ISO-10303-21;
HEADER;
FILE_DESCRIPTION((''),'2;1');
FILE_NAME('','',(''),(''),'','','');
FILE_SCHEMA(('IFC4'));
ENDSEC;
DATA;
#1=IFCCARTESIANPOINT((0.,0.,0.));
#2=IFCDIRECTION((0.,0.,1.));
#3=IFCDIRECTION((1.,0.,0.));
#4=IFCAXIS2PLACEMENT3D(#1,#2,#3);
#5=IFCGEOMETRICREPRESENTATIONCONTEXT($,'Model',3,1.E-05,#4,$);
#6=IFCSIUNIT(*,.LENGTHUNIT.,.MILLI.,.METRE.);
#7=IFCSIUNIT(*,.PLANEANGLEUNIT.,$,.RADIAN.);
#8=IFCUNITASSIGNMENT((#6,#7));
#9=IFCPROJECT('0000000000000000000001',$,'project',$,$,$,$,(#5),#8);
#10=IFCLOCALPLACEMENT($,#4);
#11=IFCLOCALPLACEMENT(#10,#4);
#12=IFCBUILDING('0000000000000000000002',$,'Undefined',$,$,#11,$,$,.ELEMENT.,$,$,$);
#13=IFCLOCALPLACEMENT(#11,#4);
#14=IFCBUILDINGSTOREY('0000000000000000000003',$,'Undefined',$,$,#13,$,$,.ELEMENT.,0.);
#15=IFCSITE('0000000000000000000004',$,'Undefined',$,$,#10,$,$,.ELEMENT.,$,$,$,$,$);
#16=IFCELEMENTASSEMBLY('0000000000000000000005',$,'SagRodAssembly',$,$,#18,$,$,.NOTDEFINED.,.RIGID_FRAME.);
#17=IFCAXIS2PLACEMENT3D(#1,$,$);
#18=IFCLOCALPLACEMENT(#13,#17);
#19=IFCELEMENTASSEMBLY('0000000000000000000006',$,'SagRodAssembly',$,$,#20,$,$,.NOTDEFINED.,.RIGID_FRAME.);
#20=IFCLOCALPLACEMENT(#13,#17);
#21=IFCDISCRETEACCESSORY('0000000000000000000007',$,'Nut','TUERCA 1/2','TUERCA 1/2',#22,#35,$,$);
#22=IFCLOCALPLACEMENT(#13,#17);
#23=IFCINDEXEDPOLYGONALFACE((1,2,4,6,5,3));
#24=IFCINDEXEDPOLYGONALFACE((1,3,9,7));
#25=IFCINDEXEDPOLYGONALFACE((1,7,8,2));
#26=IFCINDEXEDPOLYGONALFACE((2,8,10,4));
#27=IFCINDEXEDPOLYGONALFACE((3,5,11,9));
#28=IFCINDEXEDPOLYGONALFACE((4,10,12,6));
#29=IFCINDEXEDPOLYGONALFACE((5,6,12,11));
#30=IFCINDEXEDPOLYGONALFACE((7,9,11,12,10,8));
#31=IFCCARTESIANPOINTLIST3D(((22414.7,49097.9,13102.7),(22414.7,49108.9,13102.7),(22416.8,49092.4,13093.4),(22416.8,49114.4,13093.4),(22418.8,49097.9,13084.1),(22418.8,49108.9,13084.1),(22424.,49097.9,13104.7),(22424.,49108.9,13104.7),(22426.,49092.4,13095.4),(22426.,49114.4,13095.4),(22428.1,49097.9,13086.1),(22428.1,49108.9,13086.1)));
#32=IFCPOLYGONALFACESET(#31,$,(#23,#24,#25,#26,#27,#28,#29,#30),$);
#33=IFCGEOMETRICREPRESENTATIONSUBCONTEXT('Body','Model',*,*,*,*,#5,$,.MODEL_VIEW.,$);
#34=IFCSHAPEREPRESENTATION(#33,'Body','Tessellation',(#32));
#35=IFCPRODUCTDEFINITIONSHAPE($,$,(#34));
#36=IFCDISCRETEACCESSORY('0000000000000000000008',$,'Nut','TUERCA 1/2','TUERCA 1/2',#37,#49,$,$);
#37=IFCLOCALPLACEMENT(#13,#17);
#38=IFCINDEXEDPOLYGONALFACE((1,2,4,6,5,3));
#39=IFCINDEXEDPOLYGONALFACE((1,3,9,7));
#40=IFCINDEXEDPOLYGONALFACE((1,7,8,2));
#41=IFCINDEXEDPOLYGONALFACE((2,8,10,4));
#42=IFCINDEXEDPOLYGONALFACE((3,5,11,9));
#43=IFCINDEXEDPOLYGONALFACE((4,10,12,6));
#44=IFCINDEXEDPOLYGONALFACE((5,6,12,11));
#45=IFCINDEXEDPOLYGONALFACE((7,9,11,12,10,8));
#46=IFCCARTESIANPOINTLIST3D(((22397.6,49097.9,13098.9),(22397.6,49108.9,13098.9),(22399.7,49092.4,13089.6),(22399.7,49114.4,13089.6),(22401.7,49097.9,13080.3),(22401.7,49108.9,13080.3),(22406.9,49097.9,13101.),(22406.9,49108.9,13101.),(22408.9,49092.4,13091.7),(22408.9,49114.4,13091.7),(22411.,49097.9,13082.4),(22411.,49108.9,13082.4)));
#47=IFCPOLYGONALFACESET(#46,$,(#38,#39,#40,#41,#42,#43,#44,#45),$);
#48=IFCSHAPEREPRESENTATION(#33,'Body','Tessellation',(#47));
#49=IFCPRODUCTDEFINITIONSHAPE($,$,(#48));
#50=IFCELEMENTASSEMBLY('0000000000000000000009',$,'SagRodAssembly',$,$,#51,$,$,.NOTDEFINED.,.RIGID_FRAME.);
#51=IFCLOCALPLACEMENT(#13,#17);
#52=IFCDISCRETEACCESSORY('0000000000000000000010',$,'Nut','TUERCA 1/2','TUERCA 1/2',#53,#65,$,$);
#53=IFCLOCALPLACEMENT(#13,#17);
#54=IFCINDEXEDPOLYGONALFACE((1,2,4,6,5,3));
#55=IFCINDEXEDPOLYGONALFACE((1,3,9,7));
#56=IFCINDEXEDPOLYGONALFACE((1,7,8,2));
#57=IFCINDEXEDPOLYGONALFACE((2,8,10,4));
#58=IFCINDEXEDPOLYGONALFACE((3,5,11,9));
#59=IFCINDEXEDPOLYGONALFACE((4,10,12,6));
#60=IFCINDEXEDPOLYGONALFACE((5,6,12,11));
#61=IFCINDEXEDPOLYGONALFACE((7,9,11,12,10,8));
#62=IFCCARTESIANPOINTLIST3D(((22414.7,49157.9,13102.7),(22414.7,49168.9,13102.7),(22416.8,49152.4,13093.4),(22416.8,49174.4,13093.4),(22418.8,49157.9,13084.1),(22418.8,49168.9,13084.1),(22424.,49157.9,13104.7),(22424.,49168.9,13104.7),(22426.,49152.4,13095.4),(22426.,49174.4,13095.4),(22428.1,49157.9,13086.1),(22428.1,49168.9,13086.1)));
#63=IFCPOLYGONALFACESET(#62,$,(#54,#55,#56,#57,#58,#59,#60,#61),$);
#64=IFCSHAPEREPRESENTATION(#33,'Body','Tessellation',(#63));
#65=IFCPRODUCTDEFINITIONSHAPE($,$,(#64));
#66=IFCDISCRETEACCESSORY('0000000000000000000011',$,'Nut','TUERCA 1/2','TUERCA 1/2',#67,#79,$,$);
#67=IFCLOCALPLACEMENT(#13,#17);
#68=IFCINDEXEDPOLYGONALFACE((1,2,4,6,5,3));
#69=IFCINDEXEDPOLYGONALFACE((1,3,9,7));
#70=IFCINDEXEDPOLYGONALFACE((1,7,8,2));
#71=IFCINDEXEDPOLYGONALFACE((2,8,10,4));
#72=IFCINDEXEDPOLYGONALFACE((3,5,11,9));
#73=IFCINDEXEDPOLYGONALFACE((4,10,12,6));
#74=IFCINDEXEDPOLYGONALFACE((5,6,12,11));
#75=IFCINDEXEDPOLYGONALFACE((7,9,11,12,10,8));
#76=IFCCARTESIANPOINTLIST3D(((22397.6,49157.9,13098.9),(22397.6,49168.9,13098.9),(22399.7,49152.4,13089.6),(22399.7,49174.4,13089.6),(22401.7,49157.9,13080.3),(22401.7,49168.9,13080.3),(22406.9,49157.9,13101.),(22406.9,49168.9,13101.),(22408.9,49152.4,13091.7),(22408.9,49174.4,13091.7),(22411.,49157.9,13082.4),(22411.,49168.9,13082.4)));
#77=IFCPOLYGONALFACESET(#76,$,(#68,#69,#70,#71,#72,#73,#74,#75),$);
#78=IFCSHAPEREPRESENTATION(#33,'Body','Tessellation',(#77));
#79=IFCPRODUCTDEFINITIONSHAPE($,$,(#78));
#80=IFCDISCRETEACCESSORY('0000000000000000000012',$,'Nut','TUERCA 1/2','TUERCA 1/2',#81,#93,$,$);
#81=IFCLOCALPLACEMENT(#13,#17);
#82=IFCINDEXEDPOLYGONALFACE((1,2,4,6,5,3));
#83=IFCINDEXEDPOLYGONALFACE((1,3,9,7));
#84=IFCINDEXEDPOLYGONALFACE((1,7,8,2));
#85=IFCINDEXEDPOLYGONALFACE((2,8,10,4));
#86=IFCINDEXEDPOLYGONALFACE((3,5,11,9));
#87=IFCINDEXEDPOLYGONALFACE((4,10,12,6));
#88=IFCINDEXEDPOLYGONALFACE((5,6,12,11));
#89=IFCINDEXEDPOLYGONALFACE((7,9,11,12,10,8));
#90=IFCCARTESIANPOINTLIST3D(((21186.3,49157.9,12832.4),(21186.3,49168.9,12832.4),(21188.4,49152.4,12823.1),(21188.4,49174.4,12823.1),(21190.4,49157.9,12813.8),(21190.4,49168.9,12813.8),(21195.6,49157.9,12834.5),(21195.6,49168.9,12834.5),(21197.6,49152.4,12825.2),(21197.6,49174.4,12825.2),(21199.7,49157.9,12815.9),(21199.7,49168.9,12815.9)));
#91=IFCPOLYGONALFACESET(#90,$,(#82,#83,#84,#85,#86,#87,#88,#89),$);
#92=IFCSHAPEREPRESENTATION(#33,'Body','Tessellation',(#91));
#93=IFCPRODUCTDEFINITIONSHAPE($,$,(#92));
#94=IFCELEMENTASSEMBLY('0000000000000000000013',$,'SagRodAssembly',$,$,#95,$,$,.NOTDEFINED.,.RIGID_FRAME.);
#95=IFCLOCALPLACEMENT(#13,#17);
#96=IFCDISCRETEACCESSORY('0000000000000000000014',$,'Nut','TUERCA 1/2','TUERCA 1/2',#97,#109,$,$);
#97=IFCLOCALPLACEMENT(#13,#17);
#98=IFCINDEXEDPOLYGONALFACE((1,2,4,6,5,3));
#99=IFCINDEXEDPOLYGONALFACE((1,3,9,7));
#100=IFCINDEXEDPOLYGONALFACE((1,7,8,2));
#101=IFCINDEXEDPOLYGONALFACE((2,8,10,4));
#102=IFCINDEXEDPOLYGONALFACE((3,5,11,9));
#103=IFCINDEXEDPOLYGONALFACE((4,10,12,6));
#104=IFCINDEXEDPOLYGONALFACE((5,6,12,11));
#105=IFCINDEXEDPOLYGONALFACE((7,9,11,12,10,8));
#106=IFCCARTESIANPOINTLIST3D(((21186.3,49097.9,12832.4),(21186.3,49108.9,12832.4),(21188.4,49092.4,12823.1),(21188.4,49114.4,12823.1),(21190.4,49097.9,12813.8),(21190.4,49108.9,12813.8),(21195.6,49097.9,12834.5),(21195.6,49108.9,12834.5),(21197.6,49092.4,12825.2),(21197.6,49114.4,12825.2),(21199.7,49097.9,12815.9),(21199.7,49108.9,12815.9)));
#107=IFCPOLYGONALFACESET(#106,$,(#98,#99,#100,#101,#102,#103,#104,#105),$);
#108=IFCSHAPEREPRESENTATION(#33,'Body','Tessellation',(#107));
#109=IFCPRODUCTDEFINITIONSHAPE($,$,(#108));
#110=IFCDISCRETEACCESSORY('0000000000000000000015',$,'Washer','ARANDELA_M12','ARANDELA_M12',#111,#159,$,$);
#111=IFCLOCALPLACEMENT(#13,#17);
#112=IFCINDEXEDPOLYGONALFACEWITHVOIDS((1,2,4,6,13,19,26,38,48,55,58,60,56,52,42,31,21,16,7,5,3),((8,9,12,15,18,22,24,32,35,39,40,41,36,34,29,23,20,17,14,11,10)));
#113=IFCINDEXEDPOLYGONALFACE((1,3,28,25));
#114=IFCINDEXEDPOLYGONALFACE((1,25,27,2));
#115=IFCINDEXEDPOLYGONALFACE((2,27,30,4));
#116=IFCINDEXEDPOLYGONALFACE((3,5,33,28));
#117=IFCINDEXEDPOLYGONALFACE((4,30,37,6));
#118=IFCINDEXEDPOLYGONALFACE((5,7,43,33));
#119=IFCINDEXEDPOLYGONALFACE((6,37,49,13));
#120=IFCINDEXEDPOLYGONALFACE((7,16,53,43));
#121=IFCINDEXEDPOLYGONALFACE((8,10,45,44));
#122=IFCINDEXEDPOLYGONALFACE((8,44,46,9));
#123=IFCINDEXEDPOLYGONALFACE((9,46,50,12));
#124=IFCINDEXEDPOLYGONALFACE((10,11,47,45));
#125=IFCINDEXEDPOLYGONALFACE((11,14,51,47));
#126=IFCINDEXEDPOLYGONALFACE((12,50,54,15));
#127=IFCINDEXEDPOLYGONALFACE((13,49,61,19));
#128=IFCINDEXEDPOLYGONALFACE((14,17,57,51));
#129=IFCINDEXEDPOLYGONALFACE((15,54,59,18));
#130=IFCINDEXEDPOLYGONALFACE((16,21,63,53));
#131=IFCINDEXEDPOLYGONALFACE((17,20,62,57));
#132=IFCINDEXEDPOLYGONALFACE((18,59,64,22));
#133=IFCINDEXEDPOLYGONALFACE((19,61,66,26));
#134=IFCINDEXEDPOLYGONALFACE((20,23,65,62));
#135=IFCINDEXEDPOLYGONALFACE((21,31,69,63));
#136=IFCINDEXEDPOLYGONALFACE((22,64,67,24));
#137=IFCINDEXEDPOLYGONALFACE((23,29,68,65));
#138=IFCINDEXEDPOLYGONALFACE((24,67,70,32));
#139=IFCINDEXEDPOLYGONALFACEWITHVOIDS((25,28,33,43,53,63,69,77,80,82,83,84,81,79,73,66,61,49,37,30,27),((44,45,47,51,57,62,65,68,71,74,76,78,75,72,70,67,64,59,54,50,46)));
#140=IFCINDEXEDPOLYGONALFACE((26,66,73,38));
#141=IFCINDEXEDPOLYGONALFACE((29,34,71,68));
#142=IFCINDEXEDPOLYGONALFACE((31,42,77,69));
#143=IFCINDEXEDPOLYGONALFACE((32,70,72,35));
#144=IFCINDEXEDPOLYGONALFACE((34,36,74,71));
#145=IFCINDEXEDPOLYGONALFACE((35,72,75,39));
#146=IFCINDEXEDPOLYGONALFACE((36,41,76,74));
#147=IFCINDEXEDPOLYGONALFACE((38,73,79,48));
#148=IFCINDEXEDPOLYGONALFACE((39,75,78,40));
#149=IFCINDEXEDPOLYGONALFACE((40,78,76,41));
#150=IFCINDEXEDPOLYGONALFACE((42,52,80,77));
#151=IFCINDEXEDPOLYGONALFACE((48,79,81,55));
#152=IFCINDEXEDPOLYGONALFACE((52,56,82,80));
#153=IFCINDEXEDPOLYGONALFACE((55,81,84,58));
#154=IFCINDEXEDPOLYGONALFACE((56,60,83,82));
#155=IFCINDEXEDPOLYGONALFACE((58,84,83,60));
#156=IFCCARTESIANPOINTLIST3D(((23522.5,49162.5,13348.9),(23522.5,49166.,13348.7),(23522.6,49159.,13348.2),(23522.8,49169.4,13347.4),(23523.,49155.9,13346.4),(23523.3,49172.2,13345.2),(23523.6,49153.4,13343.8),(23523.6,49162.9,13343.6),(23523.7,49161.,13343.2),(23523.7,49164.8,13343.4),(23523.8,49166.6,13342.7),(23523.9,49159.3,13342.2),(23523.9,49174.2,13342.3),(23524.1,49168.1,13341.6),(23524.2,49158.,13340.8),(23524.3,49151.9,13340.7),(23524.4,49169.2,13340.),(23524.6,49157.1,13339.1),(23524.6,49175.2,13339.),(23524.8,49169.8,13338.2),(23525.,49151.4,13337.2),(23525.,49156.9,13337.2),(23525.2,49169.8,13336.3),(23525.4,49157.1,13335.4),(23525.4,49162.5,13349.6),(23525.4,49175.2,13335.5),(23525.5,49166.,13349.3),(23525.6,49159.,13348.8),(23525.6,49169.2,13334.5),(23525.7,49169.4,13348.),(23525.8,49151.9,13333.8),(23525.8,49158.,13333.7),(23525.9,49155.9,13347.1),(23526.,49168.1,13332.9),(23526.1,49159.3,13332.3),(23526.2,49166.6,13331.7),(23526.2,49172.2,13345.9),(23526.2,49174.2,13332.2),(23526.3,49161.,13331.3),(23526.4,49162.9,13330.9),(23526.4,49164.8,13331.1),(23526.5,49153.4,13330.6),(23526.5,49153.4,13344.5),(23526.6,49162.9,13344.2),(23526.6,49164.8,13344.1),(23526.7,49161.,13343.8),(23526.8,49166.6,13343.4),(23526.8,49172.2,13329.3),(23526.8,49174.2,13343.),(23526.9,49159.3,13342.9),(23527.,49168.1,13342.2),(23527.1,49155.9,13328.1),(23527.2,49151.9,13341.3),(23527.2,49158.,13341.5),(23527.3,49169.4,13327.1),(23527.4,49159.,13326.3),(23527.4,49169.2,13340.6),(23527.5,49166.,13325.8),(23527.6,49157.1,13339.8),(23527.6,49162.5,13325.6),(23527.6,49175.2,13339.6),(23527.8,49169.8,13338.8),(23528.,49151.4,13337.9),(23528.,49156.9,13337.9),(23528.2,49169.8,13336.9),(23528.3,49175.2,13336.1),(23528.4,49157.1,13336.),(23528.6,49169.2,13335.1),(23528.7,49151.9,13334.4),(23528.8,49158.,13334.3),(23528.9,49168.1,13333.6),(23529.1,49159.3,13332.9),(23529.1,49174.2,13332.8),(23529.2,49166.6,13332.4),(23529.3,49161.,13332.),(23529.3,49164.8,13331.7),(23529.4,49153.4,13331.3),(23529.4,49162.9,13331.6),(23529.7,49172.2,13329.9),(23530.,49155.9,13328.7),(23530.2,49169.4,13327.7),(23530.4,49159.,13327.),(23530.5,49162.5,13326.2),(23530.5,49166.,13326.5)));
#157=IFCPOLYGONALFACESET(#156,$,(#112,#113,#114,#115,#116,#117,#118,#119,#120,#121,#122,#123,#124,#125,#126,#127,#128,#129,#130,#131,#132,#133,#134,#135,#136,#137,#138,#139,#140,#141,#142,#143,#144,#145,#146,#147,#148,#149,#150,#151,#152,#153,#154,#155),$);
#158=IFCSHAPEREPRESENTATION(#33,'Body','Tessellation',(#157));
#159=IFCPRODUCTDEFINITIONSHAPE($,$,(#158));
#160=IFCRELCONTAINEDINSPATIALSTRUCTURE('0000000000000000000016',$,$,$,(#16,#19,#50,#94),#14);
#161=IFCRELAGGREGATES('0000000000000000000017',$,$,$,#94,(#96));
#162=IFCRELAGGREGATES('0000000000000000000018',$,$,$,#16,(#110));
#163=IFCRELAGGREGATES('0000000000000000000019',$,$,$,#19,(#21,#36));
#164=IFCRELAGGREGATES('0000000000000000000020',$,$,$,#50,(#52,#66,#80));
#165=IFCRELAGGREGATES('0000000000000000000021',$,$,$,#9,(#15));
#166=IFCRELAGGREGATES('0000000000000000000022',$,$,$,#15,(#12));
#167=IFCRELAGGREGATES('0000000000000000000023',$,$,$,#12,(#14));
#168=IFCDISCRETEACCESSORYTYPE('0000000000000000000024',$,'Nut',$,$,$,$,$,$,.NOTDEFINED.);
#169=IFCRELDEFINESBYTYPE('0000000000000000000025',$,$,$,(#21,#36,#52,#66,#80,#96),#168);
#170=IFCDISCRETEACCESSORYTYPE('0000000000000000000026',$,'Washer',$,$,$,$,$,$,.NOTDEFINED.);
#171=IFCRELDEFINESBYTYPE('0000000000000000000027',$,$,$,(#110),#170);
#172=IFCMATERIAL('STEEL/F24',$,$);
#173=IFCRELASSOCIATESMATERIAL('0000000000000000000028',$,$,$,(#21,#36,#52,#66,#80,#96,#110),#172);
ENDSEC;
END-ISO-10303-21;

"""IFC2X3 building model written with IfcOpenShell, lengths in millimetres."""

from ifc_helpers import new_model, si_unit, frame, origin_with_axes, origin_2d_with_axis, place, context, subcontext, project, spatial, polyline, hollow_circle, outline, extrude, material, type_object, element, aggregate, save


model = new_model("IFC2X3")

# Units and contexts
model_context = context("Model", 3, precision=1e-05, world=origin_with_axes())
body_context = subcontext(model_context, "Body", "Model", "MODEL_VIEW")
ifc_project = project(units=[si_unit("LENGTHUNIT", "METRE", prefix="MILLI"), si_unit("PLANEANGLEUNIT", "RADIAN")], contexts=[model_context])

# Site, building, storey
site_placement = place(None, origin_with_axes())
site = spatial("IfcSite", under=ifc_project, at=site_placement, Name="Undefined", CompositionType="ELEMENT")
building_placement = place(site_placement, origin_with_axes())
building = spatial("IfcBuilding", under=site, at=building_placement, Name="Undefined", CompositionType="ELEMENT")
storey_placement = place(building_placement, origin_with_axes())
storey = spatial("IfcBuildingStorey", under=building, at=storey_placement, Name="Undefined", CompositionType="ELEMENT", Elevation=0.0)

# Element assemblies
assembly_1_placement = place(storey_placement, origin_with_axes())
assembly_1 = element("IfcElementAssembly", 1, at=assembly_1_placement, inside=storey, Name="SagRodAssembly", AssemblyPlace="NOTDEFINED", PredefinedType="RIGID_FRAME")
ifc_material = material(Name="STEEL/F24")
assembly_2_placement = place(storey_placement, origin_with_axes())
assembly_2 = element("IfcElementAssembly", 2, at=assembly_2_placement, inside=storey, Name="SagRodAssembly", AssemblyPlace="NOTDEFINED", PredefinedType="RIGID_FRAME")

# Discrete accessories
discrete_accessory_type_1 = type_object("IfcDiscreteAccessoryType", Name="Nut")
discrete_accessory_1_placement = place(assembly_2_placement, frame((22416.8, 49103.4, 13093.4), z_axis=(-0.214887, 0.0, 0.976639), x_axis=(0.976639, 0.0, 0.214887)))
discrete_accessory_1 = element("IfcDiscreteAccessory", 3, at=discrete_accessory_1_placement, type_object=discrete_accessory_type_1, material=ifc_material, Name="Nut", Description="TUERCA 1/2", ObjectType="TUERCA 1/2", context=body_context, shape_type="SweptSolid", body=[
    extrude(outline(polyline([(-5.5, 9.5), (5.5, 9.5), (11.0, 0.0), (5.5, -9.5), (-5.5, -9.5), (-11.0, 0.0), (-5.5, 9.5)])), frame((9.5, 0.0, 0.0), z_axis=(-1.0, 0.0, 0.0), x_axis=(0.0, -1.0, 0.0)), (0.0, 0.0, 1.0), 9.5),
])
discrete_accessory_2_placement = place(assembly_2_placement, frame((22399.7, 49103.4, 13089.6), z_axis=(-0.214887, 0.0, 0.976639), x_axis=(0.976639, 0.0, 0.214887)))
discrete_accessory_2 = element("IfcDiscreteAccessory", 4, at=discrete_accessory_2_placement, type_object=discrete_accessory_type_1, material=ifc_material, Name="Nut", Description="TUERCA 1/2", ObjectType="TUERCA 1/2", context=body_context, shape_type="SweptSolid", body=[
    extrude(outline(polyline([(-5.5, 9.5), (5.5, 9.5), (11.0, 0.0), (5.5, -9.5), (-5.5, -9.5), (-11.0, 0.0), (-5.5, 9.5)])), frame((9.5, 0.0, 0.0), z_axis=(-1.0, 0.0, 0.0), x_axis=(0.0, -1.0, 0.0)), (0.0, 0.0, 1.0), 9.5),
])

# Element assembly, discrete accessories
assembly_3_placement = place(storey_placement, origin_with_axes())
assembly_3 = element("IfcElementAssembly", 5, at=assembly_3_placement, inside=storey, Name="SagRodAssembly", AssemblyPlace="NOTDEFINED", PredefinedType="RIGID_FRAME")
discrete_accessory_3_placement = place(assembly_3_placement, frame((22416.8, 49163.4, 13093.4), z_axis=(-0.214887, 0.0, 0.976639), x_axis=(0.976639, 0.0, 0.214887)))
discrete_accessory_3 = element("IfcDiscreteAccessory", 6, at=discrete_accessory_3_placement, type_object=discrete_accessory_type_1, material=ifc_material, Name="Nut", Description="TUERCA 1/2", ObjectType="TUERCA 1/2", context=body_context, shape_type="SweptSolid", body=[
    extrude(outline(polyline([(-5.5, 9.5), (5.5, 9.5), (11.0, 0.0), (5.5, -9.5), (-5.5, -9.5), (-11.0, 0.0), (-5.5, 9.5)])), frame((9.5, 0.0, 0.0), z_axis=(-1.0, 0.0, 0.0), x_axis=(0.0, -1.0, 0.0)), (0.0, 0.0, 1.0), 9.5),
])
discrete_accessory_4_placement = place(assembly_3_placement, frame((22399.7, 49163.4, 13089.6), z_axis=(-0.214887, 0.0, 0.976639), x_axis=(0.976639, 0.0, 0.214887)))
discrete_accessory_4 = element("IfcDiscreteAccessory", 7, at=discrete_accessory_4_placement, type_object=discrete_accessory_type_1, material=ifc_material, Name="Nut", Description="TUERCA 1/2", ObjectType="TUERCA 1/2", context=body_context, shape_type="SweptSolid", body=[
    extrude(outline(polyline([(-5.5, 9.5), (5.5, 9.5), (11.0, 0.0), (5.5, -9.5), (-5.5, -9.5), (-11.0, 0.0), (-5.5, 9.5)])), frame((9.5, 0.0, 0.0), z_axis=(-1.0, 0.0, 0.0), x_axis=(0.0, -1.0, 0.0)), (0.0, 0.0, 1.0), 9.5),
])
discrete_accessory_5_placement = place(assembly_3_placement, frame((21188.4, 49163.4, 12823.1), z_axis=(-0.214887, 0.0, 0.976639), x_axis=(0.976639, 0.0, 0.214887)))
discrete_accessory_5 = element("IfcDiscreteAccessory", 8, at=discrete_accessory_5_placement, type_object=discrete_accessory_type_1, material=ifc_material, Name="Nut", Description="TUERCA 1/2", ObjectType="TUERCA 1/2", context=body_context, shape_type="SweptSolid", body=[
    extrude(outline(polyline([(-5.5, 9.5), (5.5, 9.5), (11.0, 0.0), (5.5, -9.5), (-5.5, -9.5), (-11.0, 0.0), (-5.5, 9.5)])), frame((9.5, 0.0, 0.0), z_axis=(-1.0, 0.0, 0.0), x_axis=(0.0, -1.0, 0.0)), (0.0, 0.0, 1.0), 9.5),
])

# Element assembly, discrete accessory
assembly_4_placement = place(storey_placement, origin_with_axes())
assembly_4 = element("IfcElementAssembly", 9, at=assembly_4_placement, inside=storey, Name="SagRodAssembly", AssemblyPlace="NOTDEFINED", PredefinedType="RIGID_FRAME")
discrete_accessory_6_placement = place(assembly_4_placement, frame((21188.4, 49103.4, 12823.1), z_axis=(-0.214887, 0.0, 0.976639), x_axis=(0.976639, 0.0, 0.214887)))
discrete_accessory_6 = element("IfcDiscreteAccessory", 10, at=discrete_accessory_6_placement, type_object=discrete_accessory_type_1, material=ifc_material, Name="Nut", Description="TUERCA 1/2", ObjectType="TUERCA 1/2", context=body_context, shape_type="SweptSolid", body=[
    extrude(outline(polyline([(-5.5, 9.5), (5.5, 9.5), (11.0, 0.0), (5.5, -9.5), (-5.5, -9.5), (-11.0, 0.0), (-5.5, 9.5)])), frame((9.5, 0.0, 0.0), z_axis=(-1.0, 0.0, 0.0), x_axis=(0.0, -1.0, 0.0)), (0.0, 0.0, 1.0), 9.5),
])
aggregate(assembly_4, [discrete_accessory_6])

# Discrete accessory
discrete_accessory_type_2 = type_object("IfcDiscreteAccessoryType", Name="Washer")
discrete_accessory_7_placement = place(assembly_1_placement, frame((23525.0, 49163.4, 13337.2), z_axis=(-0.214887, 0.0, 0.976639), x_axis=(0.976639, 0.0, 0.214887)))
discrete_accessory_7 = element("IfcDiscreteAccessory", 11, at=discrete_accessory_7_placement, type_object=discrete_accessory_type_2, material=ifc_material, Name="Washer", Description="ARANDELA_M12", ObjectType="ARANDELA_M12", context=body_context, shape_type="SweptSolid", body=[
    extrude(hollow_circle(Radius=12.0, WallThickness=5.5, at=origin_2d_with_axis()), frame((3.0, 0.0, 0.0), z_axis=(-1.0, 0.0, 0.0), x_axis=(0.0, -1.0, 0.0)), (0.0, 0.0, 1.0), 3.0),
])
aggregate(assembly_1, [discrete_accessory_7])
aggregate(assembly_2, [discrete_accessory_1, discrete_accessory_2])
aggregate(assembly_3, [discrete_accessory_3, discrete_accessory_4, discrete_accessory_5])

save(model, "model.ifc")
